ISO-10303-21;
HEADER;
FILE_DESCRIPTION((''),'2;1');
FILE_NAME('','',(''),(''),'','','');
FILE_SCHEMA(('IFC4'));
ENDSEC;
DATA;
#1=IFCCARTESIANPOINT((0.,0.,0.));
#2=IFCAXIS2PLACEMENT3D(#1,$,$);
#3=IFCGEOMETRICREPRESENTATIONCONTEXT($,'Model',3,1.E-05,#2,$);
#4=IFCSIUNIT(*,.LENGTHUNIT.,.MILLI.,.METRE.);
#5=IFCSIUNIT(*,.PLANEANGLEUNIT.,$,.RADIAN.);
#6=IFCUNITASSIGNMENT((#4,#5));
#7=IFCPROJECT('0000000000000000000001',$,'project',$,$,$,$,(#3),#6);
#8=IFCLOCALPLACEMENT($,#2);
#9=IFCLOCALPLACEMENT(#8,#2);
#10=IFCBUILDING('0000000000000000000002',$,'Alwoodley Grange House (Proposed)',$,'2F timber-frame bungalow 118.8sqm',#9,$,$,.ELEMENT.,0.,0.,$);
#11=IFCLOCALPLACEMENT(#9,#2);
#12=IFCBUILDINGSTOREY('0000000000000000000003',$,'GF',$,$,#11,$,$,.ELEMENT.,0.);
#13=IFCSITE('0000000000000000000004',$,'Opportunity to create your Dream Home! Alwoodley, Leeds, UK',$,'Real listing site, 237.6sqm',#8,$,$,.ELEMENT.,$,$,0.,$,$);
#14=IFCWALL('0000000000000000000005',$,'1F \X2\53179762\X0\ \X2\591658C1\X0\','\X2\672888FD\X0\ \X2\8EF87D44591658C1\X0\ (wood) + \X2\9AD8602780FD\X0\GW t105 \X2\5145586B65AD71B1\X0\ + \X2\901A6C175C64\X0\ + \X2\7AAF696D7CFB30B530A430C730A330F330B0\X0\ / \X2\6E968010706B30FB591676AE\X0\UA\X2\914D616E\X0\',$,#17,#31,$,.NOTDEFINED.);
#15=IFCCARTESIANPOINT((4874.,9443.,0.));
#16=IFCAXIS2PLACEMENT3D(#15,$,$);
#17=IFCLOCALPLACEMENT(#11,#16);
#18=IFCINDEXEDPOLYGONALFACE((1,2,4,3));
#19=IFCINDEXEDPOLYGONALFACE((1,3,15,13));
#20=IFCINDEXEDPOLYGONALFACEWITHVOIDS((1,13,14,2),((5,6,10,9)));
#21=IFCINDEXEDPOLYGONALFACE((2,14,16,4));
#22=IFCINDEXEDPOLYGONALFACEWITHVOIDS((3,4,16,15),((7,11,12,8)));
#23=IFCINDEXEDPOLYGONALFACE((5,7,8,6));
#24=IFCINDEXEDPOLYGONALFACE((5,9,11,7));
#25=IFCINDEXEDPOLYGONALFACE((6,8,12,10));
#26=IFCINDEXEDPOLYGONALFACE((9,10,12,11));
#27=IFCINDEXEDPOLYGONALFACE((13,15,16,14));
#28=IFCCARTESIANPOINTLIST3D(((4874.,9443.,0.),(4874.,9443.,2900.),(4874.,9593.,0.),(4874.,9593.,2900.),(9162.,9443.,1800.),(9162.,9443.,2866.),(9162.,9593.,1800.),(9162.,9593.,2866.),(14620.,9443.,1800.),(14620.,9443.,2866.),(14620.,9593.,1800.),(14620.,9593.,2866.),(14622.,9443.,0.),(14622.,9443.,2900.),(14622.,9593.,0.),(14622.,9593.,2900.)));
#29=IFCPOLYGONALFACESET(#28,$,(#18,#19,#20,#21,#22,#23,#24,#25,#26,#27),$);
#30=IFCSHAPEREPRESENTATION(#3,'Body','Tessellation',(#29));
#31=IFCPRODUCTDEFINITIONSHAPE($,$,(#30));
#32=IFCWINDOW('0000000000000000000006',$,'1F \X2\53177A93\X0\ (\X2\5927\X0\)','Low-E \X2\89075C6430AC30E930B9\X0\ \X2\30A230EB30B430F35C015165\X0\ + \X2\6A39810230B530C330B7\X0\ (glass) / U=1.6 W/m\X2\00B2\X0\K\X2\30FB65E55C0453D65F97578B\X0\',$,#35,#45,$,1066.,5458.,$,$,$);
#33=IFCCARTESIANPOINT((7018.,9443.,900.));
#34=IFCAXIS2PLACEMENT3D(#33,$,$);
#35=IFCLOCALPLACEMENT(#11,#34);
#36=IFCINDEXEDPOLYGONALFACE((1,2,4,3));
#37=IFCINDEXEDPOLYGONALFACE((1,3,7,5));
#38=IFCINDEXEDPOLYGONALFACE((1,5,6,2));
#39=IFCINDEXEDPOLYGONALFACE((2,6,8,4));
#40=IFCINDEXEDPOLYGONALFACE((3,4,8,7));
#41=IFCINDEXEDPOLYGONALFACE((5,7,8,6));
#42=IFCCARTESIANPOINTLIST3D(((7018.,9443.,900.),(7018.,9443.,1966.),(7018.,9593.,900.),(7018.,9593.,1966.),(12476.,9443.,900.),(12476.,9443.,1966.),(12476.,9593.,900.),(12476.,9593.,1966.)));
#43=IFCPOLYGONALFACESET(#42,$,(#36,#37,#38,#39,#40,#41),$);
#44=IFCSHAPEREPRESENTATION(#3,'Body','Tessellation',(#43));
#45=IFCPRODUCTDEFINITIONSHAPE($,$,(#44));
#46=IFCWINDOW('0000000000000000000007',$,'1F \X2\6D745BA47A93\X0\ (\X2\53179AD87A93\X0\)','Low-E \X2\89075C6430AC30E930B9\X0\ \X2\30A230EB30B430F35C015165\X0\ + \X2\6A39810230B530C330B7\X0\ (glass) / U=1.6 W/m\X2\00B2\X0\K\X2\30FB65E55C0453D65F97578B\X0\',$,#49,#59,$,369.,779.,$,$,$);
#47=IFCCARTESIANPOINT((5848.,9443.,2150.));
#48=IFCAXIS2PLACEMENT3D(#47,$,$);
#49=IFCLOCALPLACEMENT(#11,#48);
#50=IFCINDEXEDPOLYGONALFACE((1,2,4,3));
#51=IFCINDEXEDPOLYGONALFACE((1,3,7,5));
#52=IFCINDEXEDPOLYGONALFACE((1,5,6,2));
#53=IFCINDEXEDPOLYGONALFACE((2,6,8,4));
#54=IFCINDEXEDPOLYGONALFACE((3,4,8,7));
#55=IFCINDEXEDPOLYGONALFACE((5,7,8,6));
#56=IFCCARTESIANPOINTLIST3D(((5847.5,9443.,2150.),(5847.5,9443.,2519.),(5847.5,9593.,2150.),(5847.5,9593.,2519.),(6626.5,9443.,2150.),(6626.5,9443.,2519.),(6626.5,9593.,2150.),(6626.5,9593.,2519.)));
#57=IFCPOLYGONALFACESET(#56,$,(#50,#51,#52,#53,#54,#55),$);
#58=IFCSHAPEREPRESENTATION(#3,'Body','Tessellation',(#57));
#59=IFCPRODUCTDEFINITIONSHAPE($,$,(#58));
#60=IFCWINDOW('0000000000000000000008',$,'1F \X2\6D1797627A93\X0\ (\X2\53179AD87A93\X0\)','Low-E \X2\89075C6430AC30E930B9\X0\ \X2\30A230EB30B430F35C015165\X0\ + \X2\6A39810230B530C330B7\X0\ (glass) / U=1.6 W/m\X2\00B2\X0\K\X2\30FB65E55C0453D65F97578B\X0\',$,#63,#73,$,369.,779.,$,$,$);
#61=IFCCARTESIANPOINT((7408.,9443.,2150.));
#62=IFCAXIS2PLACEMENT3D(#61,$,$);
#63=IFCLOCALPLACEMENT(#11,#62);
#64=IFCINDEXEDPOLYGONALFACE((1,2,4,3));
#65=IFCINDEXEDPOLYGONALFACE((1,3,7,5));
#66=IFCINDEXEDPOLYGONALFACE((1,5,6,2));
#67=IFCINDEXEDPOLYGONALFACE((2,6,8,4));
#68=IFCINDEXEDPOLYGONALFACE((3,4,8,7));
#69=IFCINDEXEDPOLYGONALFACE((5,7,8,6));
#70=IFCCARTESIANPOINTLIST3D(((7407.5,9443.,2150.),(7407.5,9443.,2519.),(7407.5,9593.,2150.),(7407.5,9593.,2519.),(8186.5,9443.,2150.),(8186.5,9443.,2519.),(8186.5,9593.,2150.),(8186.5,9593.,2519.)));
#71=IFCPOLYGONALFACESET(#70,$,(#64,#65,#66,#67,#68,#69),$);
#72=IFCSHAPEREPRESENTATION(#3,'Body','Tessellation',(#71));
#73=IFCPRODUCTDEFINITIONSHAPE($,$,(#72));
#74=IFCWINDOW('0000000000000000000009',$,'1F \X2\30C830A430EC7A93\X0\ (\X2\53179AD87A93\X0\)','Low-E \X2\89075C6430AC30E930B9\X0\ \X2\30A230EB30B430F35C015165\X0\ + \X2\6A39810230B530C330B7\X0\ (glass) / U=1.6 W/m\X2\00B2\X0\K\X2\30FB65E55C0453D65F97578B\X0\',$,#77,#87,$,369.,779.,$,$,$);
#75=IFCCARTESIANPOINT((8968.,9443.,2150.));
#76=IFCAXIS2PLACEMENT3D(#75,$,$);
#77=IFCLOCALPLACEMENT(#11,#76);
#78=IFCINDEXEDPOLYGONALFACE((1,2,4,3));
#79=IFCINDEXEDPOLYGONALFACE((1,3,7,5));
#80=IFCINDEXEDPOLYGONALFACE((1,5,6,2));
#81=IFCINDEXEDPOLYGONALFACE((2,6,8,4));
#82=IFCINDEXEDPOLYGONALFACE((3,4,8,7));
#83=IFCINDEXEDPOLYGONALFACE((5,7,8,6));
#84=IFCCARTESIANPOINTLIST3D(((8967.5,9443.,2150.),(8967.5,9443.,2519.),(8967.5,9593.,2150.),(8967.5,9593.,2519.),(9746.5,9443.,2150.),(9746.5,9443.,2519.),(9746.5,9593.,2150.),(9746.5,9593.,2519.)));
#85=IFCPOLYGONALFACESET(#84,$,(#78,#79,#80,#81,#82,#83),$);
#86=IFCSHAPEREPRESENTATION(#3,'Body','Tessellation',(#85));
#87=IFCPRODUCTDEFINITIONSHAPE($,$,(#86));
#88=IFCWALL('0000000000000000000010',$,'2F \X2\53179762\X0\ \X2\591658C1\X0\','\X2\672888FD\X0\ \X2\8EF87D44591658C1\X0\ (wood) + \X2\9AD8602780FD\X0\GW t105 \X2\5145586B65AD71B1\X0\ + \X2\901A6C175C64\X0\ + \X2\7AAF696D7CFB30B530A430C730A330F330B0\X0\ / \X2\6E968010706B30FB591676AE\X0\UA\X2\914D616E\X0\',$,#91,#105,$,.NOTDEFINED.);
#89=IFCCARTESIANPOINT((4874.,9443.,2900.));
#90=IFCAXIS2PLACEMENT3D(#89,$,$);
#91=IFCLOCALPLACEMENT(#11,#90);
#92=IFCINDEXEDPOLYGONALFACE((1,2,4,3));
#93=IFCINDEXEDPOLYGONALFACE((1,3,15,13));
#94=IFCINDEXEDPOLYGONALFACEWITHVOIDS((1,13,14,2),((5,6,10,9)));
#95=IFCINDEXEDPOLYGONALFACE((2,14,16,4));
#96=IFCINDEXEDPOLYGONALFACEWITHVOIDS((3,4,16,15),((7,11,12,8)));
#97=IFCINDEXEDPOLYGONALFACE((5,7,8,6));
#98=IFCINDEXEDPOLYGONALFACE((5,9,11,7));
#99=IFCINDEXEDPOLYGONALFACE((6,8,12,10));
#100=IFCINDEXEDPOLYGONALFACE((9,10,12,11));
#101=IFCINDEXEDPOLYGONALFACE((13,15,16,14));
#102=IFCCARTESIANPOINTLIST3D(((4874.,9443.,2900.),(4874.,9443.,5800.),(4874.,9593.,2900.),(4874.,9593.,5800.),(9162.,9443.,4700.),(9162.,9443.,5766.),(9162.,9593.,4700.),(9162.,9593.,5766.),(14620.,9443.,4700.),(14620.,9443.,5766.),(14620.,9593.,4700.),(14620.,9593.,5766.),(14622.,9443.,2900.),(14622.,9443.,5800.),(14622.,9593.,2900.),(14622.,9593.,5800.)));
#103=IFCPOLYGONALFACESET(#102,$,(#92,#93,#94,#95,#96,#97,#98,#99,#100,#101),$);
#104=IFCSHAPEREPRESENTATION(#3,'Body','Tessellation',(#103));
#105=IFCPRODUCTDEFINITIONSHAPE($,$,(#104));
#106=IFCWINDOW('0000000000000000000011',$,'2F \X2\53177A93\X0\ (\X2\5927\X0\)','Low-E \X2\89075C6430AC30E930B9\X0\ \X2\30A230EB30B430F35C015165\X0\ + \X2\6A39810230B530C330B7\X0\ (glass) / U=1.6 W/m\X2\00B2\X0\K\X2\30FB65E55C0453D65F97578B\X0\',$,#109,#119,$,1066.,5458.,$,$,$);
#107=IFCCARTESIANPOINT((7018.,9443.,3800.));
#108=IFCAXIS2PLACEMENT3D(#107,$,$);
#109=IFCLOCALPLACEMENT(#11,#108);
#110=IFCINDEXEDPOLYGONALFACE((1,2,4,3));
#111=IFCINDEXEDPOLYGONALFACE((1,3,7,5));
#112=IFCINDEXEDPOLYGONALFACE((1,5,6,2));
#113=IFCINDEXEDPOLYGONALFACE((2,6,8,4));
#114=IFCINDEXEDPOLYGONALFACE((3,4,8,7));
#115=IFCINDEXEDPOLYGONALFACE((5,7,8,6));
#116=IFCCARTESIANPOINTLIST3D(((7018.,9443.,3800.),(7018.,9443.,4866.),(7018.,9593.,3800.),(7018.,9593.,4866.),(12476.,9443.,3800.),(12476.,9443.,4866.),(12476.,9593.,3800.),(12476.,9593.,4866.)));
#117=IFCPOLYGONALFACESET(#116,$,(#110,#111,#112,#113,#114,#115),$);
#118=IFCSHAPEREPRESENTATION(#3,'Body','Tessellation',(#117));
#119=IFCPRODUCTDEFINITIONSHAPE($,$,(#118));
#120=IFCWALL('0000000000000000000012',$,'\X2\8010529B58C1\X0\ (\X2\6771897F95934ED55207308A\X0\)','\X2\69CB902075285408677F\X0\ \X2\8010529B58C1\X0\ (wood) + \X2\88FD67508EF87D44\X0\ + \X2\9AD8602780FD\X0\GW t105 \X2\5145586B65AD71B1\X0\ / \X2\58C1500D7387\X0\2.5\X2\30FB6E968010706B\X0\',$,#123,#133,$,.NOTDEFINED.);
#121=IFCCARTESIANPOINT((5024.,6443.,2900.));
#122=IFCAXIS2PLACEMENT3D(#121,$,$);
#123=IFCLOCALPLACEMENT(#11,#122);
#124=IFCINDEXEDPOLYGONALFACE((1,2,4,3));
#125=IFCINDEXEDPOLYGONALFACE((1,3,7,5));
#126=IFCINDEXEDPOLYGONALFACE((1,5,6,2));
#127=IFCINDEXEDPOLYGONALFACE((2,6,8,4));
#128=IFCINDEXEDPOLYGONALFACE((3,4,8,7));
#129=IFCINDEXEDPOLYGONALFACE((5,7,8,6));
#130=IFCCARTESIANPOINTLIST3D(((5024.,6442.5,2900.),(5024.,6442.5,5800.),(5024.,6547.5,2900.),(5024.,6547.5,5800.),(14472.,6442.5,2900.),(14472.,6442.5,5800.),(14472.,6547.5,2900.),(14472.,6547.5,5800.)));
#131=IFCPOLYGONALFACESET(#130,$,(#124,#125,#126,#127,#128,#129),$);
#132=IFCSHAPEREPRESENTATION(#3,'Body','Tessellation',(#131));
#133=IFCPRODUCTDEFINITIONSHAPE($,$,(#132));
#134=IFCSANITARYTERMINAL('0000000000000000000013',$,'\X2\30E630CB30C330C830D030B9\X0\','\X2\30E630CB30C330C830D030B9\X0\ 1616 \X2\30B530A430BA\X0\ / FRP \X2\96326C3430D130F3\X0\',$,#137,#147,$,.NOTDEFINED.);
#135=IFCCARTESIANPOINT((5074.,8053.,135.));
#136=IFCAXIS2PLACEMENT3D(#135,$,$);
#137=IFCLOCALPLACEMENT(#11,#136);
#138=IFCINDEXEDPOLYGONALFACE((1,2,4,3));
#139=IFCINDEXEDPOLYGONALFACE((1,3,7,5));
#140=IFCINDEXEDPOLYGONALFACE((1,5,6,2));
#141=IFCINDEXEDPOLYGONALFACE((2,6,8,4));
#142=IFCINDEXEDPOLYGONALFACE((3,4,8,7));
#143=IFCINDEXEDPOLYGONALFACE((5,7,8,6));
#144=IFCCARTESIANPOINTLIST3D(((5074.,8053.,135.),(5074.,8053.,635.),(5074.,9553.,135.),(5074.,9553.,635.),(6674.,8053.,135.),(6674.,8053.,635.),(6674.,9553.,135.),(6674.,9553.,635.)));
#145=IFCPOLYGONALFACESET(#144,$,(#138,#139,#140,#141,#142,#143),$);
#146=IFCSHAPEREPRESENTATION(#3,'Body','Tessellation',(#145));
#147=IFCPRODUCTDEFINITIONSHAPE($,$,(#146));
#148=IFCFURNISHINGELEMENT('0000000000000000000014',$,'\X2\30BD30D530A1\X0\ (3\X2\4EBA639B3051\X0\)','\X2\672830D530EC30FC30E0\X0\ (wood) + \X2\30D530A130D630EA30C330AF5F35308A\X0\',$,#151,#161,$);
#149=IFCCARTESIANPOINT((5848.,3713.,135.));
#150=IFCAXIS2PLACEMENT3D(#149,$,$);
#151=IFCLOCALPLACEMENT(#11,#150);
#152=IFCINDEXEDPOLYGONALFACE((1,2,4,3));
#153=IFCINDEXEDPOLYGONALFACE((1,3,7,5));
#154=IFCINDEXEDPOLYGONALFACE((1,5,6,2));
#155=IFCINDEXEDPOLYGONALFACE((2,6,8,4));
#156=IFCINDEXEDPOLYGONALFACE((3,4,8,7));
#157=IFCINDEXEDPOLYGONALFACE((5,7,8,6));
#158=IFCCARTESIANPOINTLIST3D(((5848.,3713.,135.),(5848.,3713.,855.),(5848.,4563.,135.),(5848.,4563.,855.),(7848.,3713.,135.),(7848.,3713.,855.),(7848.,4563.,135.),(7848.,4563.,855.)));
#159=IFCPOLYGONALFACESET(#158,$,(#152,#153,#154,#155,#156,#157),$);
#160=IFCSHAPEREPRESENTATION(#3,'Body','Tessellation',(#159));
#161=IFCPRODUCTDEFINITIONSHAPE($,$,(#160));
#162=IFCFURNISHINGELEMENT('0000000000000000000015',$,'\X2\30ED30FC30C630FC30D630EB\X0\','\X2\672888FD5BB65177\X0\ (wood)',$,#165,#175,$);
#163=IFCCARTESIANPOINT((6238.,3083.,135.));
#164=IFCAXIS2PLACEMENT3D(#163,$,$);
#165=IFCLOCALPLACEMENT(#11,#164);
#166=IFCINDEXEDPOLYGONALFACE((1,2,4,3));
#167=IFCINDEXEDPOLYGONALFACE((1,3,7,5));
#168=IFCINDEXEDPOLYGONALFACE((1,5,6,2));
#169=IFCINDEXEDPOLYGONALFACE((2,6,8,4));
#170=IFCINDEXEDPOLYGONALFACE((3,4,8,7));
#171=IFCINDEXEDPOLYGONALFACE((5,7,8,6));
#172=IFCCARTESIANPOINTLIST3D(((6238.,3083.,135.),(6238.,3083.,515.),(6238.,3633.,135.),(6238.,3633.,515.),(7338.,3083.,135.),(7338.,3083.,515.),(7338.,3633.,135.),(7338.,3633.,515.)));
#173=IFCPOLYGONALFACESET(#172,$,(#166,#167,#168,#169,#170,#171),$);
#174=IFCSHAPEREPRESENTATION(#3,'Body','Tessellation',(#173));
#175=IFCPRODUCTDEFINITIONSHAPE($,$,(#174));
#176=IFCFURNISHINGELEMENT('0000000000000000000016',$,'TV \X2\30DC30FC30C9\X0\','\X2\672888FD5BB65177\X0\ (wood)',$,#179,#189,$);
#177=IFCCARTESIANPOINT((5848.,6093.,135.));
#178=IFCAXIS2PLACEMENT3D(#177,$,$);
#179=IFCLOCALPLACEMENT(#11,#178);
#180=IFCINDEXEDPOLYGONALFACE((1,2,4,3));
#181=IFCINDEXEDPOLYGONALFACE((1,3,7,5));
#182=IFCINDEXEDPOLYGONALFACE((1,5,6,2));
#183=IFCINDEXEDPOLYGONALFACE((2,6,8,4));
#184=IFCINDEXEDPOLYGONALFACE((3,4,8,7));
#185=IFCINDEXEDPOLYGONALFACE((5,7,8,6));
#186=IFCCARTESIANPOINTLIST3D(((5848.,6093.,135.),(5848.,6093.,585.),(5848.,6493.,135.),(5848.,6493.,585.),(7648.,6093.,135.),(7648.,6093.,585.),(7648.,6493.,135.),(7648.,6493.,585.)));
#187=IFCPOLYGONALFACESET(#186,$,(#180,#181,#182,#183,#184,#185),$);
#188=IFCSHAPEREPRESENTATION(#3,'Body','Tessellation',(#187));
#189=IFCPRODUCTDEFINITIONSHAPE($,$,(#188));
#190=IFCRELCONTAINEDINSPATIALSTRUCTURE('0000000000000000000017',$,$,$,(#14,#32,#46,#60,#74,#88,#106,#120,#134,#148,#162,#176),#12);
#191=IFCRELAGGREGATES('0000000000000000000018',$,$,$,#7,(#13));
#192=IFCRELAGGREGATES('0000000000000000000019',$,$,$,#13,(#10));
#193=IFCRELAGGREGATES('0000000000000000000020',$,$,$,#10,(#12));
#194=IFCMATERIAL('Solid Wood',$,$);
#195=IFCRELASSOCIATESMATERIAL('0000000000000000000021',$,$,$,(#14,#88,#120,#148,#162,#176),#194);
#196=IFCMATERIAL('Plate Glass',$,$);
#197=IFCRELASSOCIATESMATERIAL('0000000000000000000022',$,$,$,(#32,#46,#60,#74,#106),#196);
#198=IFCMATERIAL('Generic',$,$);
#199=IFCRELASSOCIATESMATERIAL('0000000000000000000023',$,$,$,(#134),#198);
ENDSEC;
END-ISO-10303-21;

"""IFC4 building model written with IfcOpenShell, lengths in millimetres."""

from ifc_helpers import new_model, si_unit, frame, frame_2d, origin, place, context, project, spatial, rectangle, extrude, material, element, fill, save


model = new_model("IFC4")

# Units and contexts
model_context = context("Model", 3, precision=1e-05, world=origin())
ifc_project = project(units=[si_unit("LENGTHUNIT", "METRE", prefix="MILLI"), si_unit("PLANEANGLEUNIT", "RADIAN")], contexts=[model_context])

# Site, building, storey
site_placement = place(None, origin())
site = spatial("IfcSite", under=ifc_project, at=site_placement, Name="Opportunity to create your Dream Home! Alwoodley, Leeds, UK", ObjectType="Real listing site, 237.6sqm", CompositionType="ELEMENT", RefElevation=0.0)
building_placement = place(site_placement, origin())
building = spatial("IfcBuilding", under=site, at=building_placement, Name="Alwoodley Grange House (Proposed)", ObjectType="2F timber-frame bungalow 118.8sqm", CompositionType="ELEMENT", ElevationOfRefHeight=0.0, ElevationOfTerrain=0.0)
storey_placement = place(building_placement, origin())
storey = spatial("IfcBuildingStorey", under=building, at=storey_placement, Name="GF", CompositionType="ELEMENT", Elevation=0.0)

# Wall, openings, windows
ifc_material_1 = material(Name="Solid Wood")
wall_1_placement = place(storey_placement, frame((4874.0, 9443.0, 0.0)))
wall_1 = element("IfcWall", 1, at=wall_1_placement, inside=storey, material=ifc_material_1, Name="1F 北面 外壁", Description="木製 軸組外壁 (wood) + 高性能GW t105 充填断熱 + 通気層 + 窯業系サイディング / 準耐火・外皮UA配慮", PredefinedType="NOTDEFINED", context=model_context, shape_type="SweptSolid", body=[
    extrude(rectangle(XDim=9748.0, YDim=150.0, at=frame_2d((4874.0, 75.0))), frame((4874.0, 9443.0, 0.0)), (0.0, 0.0, 1.0), 2900.0),
])
opening_1_placement = place(storey_placement, frame((7018.0, 9443.0, 900.0)))
opening_1 = element("IfcOpeningElement", 2, at=opening_1_placement, cuts=wall_1, PredefinedType="NOTDEFINED", context=model_context, shape_type="SweptSolid", body=[
    extrude(rectangle(XDim=5458.0, YDim=150.0, at=frame_2d((2729.0, 75.0))), frame((7018.0, 9443.0, 900.0)), (0.0, 0.0, 1.0), 1066.0),
])
opening_2_placement = place(storey_placement, frame((5848.0, 9443.0, 2150.0)))
opening_2 = element("IfcOpeningElement", 3, at=opening_2_placement, cuts=wall_1, PredefinedType="NOTDEFINED", context=model_context, shape_type="SweptSolid", body=[
    extrude(rectangle(XDim=779.0, YDim=150.0, at=frame_2d((389.0, 75.0))), frame((5848.0, 9443.0, 2150.0)), (0.0, 0.0, 1.0), 369.0),
])
opening_3_placement = place(storey_placement, frame((7408.0, 9443.0, 2150.0)))
opening_3 = element("IfcOpeningElement", 4, at=opening_3_placement, cuts=wall_1, PredefinedType="NOTDEFINED", context=model_context, shape_type="SweptSolid", body=[
    extrude(rectangle(XDim=779.0, YDim=150.0, at=frame_2d((389.0, 75.0))), frame((7408.0, 9443.0, 2150.0)), (0.0, 0.0, 1.0), 369.0),
])
opening_4_placement = place(storey_placement, frame((8968.0, 9443.0, 2150.0)))
opening_4 = element("IfcOpeningElement", 5, at=opening_4_placement, cuts=wall_1, PredefinedType="NOTDEFINED", context=model_context, shape_type="SweptSolid", body=[
    extrude(rectangle(XDim=779.0, YDim=150.0, at=frame_2d((389.0, 75.0))), frame((8968.0, 9443.0, 2150.0)), (0.0, 0.0, 1.0), 369.0),
])
ifc_material_2 = material(Name="Plate Glass")
window_1_placement = place(storey_placement, frame((7018.0, 9443.0, 900.0)))
window_1 = element("IfcWindow", 6, at=window_1_placement, inside=storey, material=ifc_material_2, Name="1F 北窓 (大)", Description="Low-E 複層ガラス アルゴン封入 + 樹脂サッシ (glass) / U=1.6 W/m²K・日射取得型", OverallHeight=1066.0, OverallWidth=5458.0, context=model_context, shape_type="SweptSolid", body=[
    extrude(rectangle(XDim=5458.0, YDim=150.0, at=frame_2d((2729.0, 75.0))), frame((7018.0, 9443.0, 900.0)), (0.0, 0.0, 1.0), 1066.0),
])
fill(opening_1, window_1)
window_2_placement = place(storey_placement, frame((5848.0, 9443.0, 2150.0)))
window_2 = element("IfcWindow", 7, at=window_2_placement, inside=storey, material=ifc_material_2, Name="1F 浴室窓 (北高窓)", Description="Low-E 複層ガラス アルゴン封入 + 樹脂サッシ (glass) / U=1.6 W/m²K・日射取得型", OverallHeight=369.0, OverallWidth=779.0, context=model_context, shape_type="SweptSolid", body=[
    extrude(rectangle(XDim=779.0, YDim=150.0, at=frame_2d((389.0, 75.0))), frame((5848.0, 9443.0, 2150.0)), (0.0, 0.0, 1.0), 369.0),
])
fill(opening_2, window_2)
window_3_placement = place(storey_placement, frame((7408.0, 9443.0, 2150.0)))
window_3 = element("IfcWindow", 8, at=window_3_placement, inside=storey, material=ifc_material_2, Name="1F 洗面窓 (北高窓)", Description="Low-E 複層ガラス アルゴン封入 + 樹脂サッシ (glass) / U=1.6 W/m²K・日射取得型", OverallHeight=369.0, OverallWidth=779.0, context=model_context, shape_type="SweptSolid", body=[
    extrude(rectangle(XDim=779.0, YDim=150.0, at=frame_2d((389.0, 75.0))), frame((7408.0, 9443.0, 2150.0)), (0.0, 0.0, 1.0), 369.0),
])
fill(opening_3, window_3)
window_4_placement = place(storey_placement, frame((8968.0, 9443.0, 2150.0)))
window_4 = element("IfcWindow", 9, at=window_4_placement, inside=storey, material=ifc_material_2, Name="1F トイレ窓 (北高窓)", Description="Low-E 複層ガラス アルゴン封入 + 樹脂サッシ (glass) / U=1.6 W/m²K・日射取得型", OverallHeight=369.0, OverallWidth=779.0, context=model_context, shape_type="SweptSolid", body=[
    extrude(rectangle(XDim=779.0, YDim=150.0, at=frame_2d((389.0, 75.0))), frame((8968.0, 9443.0, 2150.0)), (0.0, 0.0, 1.0), 369.0),
])
fill(opening_4, window_4)

# Wall, opening, window
wall_2_placement = place(storey_placement, frame((4874.0, 9443.0, 2900.0)))
wall_2 = element("IfcWall", 10, at=wall_2_placement, inside=storey, material=ifc_material_1, Name="2F 北面 外壁", Description="木製 軸組外壁 (wood) + 高性能GW t105 充填断熱 + 通気層 + 窯業系サイディング / 準耐火・外皮UA配慮", PredefinedType="NOTDEFINED", context=model_context, shape_type="SweptSolid", body=[
    extrude(rectangle(XDim=9748.0, YDim=150.0, at=frame_2d((4874.0, 75.0))), frame((4874.0, 9443.0, 2900.0)), (0.0, 0.0, 1.0), 2900.0),
])
opening_5_placement = place(storey_placement, frame((7018.0, 9443.0, 3800.0)))
opening_5 = element("IfcOpeningElement", 11, at=opening_5_placement, cuts=wall_2, PredefinedType="NOTDEFINED", context=model_context, shape_type="SweptSolid", body=[
    extrude(rectangle(XDim=5458.0, YDim=150.0, at=frame_2d((2729.0, 75.0))), frame((7018.0, 9443.0, 3800.0)), (0.0, 0.0, 1.0), 1066.0),
])
window_5_placement = place(storey_placement, frame((7018.0, 9443.0, 3800.0)))
window_5 = element("IfcWindow", 12, at=window_5_placement, inside=storey, material=ifc_material_2, Name="2F 北窓 (大)", Description="Low-E 複層ガラス アルゴン封入 + 樹脂サッシ (glass) / U=1.6 W/m²K・日射取得型", OverallHeight=1066.0, OverallWidth=5458.0, context=model_context, shape_type="SweptSolid", body=[
    extrude(rectangle(XDim=5458.0, YDim=150.0, at=frame_2d((2729.0, 75.0))), frame((7018.0, 9443.0, 3800.0)), (0.0, 0.0, 1.0), 1066.0),
])
fill(opening_5, window_5)

# Wall
wall_3_placement = place(storey_placement, frame((5024.0, 6443.0, 2900.0)))
element("IfcWall", 13, at=wall_3_placement, inside=storey, material=ifc_material_1, Name="耐力壁 (東西間仕切り)", Description="構造用合板 耐力壁 (wood) + 製材軸組 + 高性能GW t105 充填断熱 / 壁倍率2.5・準耐火", PredefinedType="NOTDEFINED", context=model_context, shape_type="SweptSolid", body=[
    extrude(rectangle(XDim=9448.0, YDim=105.0, at=frame_2d((4724.0, 52.0))), frame((5024.0, 6443.0, 2900.0)), (0.0, 0.0, 1.0), 2900.0),
])

# Sanitary terminal
ifc_material_3 = material(Name="Generic")
sanitary_terminal_placement = place(storey_placement, frame((5074.0, 8053.0, 135.0)))
element("IfcSanitaryTerminal", 14, at=sanitary_terminal_placement, inside=storey, material=ifc_material_3, Name="ユニットバス", Description="ユニットバス 1616 サイズ / FRP 防水パン", PredefinedType="NOTDEFINED", context=model_context, shape_type="SweptSolid", body=[
    extrude(rectangle(XDim=1600.0, YDim=1500.0, at=frame_2d((800.0, 750.0))), frame((5074.0, 8053.0, 135.0)), (0.0, 0.0, 1.0), 500.0),
])

# Furnishing elements
furnishing_1_placement = place(storey_placement, frame((5848.0, 3713.0, 135.0)))
element("IfcFurnishingElement", 15, at=furnishing_1_placement, inside=storey, material=ifc_material_1, Name="ソファ (3人掛け)", Description="木フレーム (wood) + ファブリック張り", context=model_context, shape_type="SweptSolid", body=[
    extrude(rectangle(XDim=2000.0, YDim=850.0, at=frame_2d((1000.0, 425.0))), frame((5848.0, 3713.0, 135.0)), (0.0, 0.0, 1.0), 720.0),
])
furnishing_2_placement = place(storey_placement, frame((6238.0, 3083.0, 135.0)))
element("IfcFurnishingElement", 16, at=furnishing_2_placement, inside=storey, material=ifc_material_1, Name="ローテーブル", Description="木製家具 (wood)", context=model_context, shape_type="SweptSolid", body=[
    extrude(rectangle(XDim=1100.0, YDim=550.0, at=frame_2d((550.0, 275.0))), frame((6238.0, 3083.0, 135.0)), (0.0, 0.0, 1.0), 380.0),
])
furnishing_3_placement = place(storey_placement, frame((5848.0, 6093.0, 135.0)))
element("IfcFurnishingElement", 17, at=furnishing_3_placement, inside=storey, material=ifc_material_1, Name="TV ボード", Description="木製家具 (wood)", context=model_context, shape_type="SweptSolid", body=[
    extrude(rectangle(XDim=1800.0, YDim=400.0, at=frame_2d((900.0, 200.0))), frame((5848.0, 6093.0, 135.0)), (0.0, 0.0, 1.0), 450.0),
])

save(model, "model.ifc")
